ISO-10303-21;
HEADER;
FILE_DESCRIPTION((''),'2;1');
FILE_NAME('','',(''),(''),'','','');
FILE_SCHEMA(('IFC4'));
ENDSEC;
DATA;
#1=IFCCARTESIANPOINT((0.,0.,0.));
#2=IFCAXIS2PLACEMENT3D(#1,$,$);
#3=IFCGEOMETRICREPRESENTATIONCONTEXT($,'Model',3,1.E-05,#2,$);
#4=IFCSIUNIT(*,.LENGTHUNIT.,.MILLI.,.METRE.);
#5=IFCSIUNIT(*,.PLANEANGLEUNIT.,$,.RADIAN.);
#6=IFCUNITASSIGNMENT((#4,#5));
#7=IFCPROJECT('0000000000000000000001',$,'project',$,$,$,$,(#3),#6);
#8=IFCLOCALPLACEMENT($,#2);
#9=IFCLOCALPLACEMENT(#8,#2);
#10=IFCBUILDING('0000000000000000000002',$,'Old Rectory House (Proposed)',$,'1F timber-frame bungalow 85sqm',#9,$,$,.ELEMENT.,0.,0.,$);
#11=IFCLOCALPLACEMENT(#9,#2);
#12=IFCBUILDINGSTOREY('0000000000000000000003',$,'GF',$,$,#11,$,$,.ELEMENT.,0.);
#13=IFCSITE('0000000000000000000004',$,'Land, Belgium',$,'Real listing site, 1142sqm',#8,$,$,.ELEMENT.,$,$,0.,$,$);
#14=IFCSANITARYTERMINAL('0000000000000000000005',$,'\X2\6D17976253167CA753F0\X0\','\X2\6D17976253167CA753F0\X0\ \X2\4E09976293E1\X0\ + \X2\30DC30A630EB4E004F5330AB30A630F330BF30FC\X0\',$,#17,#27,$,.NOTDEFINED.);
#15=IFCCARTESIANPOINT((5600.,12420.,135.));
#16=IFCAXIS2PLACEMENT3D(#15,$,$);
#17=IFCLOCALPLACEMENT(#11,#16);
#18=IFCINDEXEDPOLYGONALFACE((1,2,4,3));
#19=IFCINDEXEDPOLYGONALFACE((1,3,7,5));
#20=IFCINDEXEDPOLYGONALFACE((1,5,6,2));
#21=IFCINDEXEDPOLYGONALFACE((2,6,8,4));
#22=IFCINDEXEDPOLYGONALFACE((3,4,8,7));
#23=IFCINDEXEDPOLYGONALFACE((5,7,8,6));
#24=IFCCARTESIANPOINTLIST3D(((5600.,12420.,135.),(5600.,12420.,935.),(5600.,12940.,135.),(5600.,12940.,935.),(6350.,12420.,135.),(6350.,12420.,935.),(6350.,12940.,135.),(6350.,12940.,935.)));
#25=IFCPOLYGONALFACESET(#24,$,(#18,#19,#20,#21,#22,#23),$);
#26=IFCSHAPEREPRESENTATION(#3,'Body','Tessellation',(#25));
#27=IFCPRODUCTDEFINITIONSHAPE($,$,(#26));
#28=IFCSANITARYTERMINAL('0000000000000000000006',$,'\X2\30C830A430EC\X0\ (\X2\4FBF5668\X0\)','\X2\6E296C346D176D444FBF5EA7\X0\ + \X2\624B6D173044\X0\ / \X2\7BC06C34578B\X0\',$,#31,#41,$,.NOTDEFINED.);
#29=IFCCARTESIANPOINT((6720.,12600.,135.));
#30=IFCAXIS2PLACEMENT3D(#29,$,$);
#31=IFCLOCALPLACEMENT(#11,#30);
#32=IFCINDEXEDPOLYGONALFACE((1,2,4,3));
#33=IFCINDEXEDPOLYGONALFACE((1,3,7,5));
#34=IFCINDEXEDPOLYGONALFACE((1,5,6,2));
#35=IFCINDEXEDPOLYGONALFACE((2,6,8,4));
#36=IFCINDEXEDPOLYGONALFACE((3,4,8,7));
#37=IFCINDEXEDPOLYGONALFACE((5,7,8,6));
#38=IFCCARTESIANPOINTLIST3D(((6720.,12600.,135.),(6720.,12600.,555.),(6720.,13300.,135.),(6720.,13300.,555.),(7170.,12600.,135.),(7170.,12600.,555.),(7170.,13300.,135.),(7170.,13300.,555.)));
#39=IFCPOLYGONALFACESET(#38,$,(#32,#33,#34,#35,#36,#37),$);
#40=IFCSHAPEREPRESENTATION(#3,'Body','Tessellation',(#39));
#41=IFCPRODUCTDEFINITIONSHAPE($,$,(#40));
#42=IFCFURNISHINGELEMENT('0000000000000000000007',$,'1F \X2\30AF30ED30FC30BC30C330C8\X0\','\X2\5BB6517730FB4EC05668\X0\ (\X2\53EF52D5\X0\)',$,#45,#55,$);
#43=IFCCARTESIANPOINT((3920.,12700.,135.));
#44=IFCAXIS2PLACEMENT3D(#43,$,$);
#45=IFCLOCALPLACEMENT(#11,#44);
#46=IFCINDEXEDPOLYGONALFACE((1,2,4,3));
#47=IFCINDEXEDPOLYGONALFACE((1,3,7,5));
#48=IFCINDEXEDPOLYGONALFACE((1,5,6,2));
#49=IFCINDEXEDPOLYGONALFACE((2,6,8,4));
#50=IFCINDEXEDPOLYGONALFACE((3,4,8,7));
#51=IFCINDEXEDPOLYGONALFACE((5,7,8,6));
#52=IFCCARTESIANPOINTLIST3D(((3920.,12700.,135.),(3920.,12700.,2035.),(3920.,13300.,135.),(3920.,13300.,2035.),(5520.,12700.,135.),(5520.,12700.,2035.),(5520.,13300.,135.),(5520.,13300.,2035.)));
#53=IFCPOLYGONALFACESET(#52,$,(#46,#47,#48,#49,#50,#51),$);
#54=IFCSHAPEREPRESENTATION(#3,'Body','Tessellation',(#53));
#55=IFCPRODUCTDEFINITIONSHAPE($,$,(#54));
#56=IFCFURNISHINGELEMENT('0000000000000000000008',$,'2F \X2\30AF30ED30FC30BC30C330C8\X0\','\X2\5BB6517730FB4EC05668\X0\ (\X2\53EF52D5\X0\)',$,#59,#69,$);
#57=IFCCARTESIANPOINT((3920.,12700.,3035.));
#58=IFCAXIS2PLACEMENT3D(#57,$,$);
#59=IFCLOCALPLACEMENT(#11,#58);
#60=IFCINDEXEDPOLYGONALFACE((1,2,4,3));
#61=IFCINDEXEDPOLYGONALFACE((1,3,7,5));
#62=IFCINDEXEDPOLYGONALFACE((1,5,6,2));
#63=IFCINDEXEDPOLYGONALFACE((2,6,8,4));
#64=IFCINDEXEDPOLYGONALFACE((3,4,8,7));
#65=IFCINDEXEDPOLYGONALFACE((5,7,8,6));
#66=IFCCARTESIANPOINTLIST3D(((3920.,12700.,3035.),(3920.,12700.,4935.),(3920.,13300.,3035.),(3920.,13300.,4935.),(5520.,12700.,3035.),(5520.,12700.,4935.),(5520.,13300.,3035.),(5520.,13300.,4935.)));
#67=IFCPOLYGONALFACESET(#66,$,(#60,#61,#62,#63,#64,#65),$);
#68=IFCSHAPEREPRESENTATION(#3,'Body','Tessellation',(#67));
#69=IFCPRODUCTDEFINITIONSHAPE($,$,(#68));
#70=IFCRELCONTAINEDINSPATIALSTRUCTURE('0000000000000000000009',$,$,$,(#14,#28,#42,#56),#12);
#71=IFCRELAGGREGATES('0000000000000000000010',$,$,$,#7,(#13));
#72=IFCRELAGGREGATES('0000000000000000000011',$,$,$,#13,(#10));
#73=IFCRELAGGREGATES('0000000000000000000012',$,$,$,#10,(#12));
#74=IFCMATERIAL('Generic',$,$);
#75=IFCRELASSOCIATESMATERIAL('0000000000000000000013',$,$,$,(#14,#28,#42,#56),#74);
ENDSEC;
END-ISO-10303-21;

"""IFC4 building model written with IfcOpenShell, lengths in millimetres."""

from ifc_helpers import new_model, si_unit, frame, frame_2d, origin, place, context, project, spatial, rectangle, extrude, material, element, save


model = new_model("IFC4")

# Units and contexts
model_context = context("Model", 3, precision=1e-05, world=origin())
ifc_project = project(units=[si_unit("LENGTHUNIT", "METRE", prefix="MILLI"), si_unit("PLANEANGLEUNIT", "RADIAN")], contexts=[model_context])

# Site, building, storey
site_placement = place(None, origin())
site = spatial("IfcSite", under=ifc_project, at=site_placement, Name="Land, Belgium", ObjectType="Real listing site, 1142sqm", CompositionType="ELEMENT", RefElevation=0.0)
building_placement = place(site_placement, origin())
building = spatial("IfcBuilding", under=site, at=building_placement, Name="Old Rectory House (Proposed)", ObjectType="1F timber-frame bungalow 85sqm", CompositionType="ELEMENT", ElevationOfRefHeight=0.0, ElevationOfTerrain=0.0)
storey_placement = place(building_placement, origin())
storey = spatial("IfcBuildingStorey", under=building, at=storey_placement, Name="GF", CompositionType="ELEMENT", Elevation=0.0)

# Shared definitions
ifc_material_1 = material(Name="Generic")

# Sanitary terminals
sanitary_terminal_1_placement = place(storey_placement, frame((5600.0, 12420.0, 135.0)))
element("IfcSanitaryTerminal", 1, at=sanitary_terminal_1_placement, inside=storey, material=ifc_material_1, Name="洗面化粧台", Description="洗面化粧台 三面鏡 + ボウル一体カウンター", PredefinedType="NOTDEFINED", context=model_context, shape_type="SweptSolid", body=[
    extrude(rectangle(XDim=750.0, YDim=520.0, at=frame_2d((375.0, 260.0))), frame((5600.0, 12420.0, 135.0)), (0.0, 0.0, 1.0), 800.0),
])
sanitary_terminal_2_placement = place(storey_placement, frame((6720.0, 12600.0, 135.0)))
element("IfcSanitaryTerminal", 2, at=sanitary_terminal_2_placement, inside=storey, material=ifc_material_1, Name="トイレ (便器)", Description="温水洗浄便座 + 手洗い / 節水型", PredefinedType="NOTDEFINED", context=model_context, shape_type="SweptSolid", body=[
    extrude(rectangle(XDim=450.0, YDim=700.0, at=frame_2d((225.0, 350.0))), frame((6720.0, 12600.0, 135.0)), (0.0, 0.0, 1.0), 420.0),
])

# Furnishing elements
furnishing_1_placement = place(storey_placement, frame((3920.0, 12700.0, 135.0)))
element("IfcFurnishingElement", 3, at=furnishing_1_placement, inside=storey, material=ifc_material_1, Name="1F クローゼット", Description="家具・什器 (可動)", context=model_context, shape_type="SweptSolid", body=[
    extrude(rectangle(XDim=1600.0, YDim=600.0, at=frame_2d((800.0, 300.0))), frame((3920.0, 12700.0, 135.0)), (0.0, 0.0, 1.0), 1900.0),
])
furnishing_2_placement = place(storey_placement, frame((3920.0, 12700.0, 3035.0)))
element("IfcFurnishingElement", 4, at=furnishing_2_placement, inside=storey, material=ifc_material_1, Name="2F クローゼット", Description="家具・什器 (可動)", context=model_context, shape_type="SweptSolid", body=[
    extrude(rectangle(XDim=1600.0, YDim=600.0, at=frame_2d((800.0, 300.0))), frame((3920.0, 12700.0, 3035.0)), (0.0, 0.0, 1.0), 1900.0),
])

save(model, "model.ifc")
